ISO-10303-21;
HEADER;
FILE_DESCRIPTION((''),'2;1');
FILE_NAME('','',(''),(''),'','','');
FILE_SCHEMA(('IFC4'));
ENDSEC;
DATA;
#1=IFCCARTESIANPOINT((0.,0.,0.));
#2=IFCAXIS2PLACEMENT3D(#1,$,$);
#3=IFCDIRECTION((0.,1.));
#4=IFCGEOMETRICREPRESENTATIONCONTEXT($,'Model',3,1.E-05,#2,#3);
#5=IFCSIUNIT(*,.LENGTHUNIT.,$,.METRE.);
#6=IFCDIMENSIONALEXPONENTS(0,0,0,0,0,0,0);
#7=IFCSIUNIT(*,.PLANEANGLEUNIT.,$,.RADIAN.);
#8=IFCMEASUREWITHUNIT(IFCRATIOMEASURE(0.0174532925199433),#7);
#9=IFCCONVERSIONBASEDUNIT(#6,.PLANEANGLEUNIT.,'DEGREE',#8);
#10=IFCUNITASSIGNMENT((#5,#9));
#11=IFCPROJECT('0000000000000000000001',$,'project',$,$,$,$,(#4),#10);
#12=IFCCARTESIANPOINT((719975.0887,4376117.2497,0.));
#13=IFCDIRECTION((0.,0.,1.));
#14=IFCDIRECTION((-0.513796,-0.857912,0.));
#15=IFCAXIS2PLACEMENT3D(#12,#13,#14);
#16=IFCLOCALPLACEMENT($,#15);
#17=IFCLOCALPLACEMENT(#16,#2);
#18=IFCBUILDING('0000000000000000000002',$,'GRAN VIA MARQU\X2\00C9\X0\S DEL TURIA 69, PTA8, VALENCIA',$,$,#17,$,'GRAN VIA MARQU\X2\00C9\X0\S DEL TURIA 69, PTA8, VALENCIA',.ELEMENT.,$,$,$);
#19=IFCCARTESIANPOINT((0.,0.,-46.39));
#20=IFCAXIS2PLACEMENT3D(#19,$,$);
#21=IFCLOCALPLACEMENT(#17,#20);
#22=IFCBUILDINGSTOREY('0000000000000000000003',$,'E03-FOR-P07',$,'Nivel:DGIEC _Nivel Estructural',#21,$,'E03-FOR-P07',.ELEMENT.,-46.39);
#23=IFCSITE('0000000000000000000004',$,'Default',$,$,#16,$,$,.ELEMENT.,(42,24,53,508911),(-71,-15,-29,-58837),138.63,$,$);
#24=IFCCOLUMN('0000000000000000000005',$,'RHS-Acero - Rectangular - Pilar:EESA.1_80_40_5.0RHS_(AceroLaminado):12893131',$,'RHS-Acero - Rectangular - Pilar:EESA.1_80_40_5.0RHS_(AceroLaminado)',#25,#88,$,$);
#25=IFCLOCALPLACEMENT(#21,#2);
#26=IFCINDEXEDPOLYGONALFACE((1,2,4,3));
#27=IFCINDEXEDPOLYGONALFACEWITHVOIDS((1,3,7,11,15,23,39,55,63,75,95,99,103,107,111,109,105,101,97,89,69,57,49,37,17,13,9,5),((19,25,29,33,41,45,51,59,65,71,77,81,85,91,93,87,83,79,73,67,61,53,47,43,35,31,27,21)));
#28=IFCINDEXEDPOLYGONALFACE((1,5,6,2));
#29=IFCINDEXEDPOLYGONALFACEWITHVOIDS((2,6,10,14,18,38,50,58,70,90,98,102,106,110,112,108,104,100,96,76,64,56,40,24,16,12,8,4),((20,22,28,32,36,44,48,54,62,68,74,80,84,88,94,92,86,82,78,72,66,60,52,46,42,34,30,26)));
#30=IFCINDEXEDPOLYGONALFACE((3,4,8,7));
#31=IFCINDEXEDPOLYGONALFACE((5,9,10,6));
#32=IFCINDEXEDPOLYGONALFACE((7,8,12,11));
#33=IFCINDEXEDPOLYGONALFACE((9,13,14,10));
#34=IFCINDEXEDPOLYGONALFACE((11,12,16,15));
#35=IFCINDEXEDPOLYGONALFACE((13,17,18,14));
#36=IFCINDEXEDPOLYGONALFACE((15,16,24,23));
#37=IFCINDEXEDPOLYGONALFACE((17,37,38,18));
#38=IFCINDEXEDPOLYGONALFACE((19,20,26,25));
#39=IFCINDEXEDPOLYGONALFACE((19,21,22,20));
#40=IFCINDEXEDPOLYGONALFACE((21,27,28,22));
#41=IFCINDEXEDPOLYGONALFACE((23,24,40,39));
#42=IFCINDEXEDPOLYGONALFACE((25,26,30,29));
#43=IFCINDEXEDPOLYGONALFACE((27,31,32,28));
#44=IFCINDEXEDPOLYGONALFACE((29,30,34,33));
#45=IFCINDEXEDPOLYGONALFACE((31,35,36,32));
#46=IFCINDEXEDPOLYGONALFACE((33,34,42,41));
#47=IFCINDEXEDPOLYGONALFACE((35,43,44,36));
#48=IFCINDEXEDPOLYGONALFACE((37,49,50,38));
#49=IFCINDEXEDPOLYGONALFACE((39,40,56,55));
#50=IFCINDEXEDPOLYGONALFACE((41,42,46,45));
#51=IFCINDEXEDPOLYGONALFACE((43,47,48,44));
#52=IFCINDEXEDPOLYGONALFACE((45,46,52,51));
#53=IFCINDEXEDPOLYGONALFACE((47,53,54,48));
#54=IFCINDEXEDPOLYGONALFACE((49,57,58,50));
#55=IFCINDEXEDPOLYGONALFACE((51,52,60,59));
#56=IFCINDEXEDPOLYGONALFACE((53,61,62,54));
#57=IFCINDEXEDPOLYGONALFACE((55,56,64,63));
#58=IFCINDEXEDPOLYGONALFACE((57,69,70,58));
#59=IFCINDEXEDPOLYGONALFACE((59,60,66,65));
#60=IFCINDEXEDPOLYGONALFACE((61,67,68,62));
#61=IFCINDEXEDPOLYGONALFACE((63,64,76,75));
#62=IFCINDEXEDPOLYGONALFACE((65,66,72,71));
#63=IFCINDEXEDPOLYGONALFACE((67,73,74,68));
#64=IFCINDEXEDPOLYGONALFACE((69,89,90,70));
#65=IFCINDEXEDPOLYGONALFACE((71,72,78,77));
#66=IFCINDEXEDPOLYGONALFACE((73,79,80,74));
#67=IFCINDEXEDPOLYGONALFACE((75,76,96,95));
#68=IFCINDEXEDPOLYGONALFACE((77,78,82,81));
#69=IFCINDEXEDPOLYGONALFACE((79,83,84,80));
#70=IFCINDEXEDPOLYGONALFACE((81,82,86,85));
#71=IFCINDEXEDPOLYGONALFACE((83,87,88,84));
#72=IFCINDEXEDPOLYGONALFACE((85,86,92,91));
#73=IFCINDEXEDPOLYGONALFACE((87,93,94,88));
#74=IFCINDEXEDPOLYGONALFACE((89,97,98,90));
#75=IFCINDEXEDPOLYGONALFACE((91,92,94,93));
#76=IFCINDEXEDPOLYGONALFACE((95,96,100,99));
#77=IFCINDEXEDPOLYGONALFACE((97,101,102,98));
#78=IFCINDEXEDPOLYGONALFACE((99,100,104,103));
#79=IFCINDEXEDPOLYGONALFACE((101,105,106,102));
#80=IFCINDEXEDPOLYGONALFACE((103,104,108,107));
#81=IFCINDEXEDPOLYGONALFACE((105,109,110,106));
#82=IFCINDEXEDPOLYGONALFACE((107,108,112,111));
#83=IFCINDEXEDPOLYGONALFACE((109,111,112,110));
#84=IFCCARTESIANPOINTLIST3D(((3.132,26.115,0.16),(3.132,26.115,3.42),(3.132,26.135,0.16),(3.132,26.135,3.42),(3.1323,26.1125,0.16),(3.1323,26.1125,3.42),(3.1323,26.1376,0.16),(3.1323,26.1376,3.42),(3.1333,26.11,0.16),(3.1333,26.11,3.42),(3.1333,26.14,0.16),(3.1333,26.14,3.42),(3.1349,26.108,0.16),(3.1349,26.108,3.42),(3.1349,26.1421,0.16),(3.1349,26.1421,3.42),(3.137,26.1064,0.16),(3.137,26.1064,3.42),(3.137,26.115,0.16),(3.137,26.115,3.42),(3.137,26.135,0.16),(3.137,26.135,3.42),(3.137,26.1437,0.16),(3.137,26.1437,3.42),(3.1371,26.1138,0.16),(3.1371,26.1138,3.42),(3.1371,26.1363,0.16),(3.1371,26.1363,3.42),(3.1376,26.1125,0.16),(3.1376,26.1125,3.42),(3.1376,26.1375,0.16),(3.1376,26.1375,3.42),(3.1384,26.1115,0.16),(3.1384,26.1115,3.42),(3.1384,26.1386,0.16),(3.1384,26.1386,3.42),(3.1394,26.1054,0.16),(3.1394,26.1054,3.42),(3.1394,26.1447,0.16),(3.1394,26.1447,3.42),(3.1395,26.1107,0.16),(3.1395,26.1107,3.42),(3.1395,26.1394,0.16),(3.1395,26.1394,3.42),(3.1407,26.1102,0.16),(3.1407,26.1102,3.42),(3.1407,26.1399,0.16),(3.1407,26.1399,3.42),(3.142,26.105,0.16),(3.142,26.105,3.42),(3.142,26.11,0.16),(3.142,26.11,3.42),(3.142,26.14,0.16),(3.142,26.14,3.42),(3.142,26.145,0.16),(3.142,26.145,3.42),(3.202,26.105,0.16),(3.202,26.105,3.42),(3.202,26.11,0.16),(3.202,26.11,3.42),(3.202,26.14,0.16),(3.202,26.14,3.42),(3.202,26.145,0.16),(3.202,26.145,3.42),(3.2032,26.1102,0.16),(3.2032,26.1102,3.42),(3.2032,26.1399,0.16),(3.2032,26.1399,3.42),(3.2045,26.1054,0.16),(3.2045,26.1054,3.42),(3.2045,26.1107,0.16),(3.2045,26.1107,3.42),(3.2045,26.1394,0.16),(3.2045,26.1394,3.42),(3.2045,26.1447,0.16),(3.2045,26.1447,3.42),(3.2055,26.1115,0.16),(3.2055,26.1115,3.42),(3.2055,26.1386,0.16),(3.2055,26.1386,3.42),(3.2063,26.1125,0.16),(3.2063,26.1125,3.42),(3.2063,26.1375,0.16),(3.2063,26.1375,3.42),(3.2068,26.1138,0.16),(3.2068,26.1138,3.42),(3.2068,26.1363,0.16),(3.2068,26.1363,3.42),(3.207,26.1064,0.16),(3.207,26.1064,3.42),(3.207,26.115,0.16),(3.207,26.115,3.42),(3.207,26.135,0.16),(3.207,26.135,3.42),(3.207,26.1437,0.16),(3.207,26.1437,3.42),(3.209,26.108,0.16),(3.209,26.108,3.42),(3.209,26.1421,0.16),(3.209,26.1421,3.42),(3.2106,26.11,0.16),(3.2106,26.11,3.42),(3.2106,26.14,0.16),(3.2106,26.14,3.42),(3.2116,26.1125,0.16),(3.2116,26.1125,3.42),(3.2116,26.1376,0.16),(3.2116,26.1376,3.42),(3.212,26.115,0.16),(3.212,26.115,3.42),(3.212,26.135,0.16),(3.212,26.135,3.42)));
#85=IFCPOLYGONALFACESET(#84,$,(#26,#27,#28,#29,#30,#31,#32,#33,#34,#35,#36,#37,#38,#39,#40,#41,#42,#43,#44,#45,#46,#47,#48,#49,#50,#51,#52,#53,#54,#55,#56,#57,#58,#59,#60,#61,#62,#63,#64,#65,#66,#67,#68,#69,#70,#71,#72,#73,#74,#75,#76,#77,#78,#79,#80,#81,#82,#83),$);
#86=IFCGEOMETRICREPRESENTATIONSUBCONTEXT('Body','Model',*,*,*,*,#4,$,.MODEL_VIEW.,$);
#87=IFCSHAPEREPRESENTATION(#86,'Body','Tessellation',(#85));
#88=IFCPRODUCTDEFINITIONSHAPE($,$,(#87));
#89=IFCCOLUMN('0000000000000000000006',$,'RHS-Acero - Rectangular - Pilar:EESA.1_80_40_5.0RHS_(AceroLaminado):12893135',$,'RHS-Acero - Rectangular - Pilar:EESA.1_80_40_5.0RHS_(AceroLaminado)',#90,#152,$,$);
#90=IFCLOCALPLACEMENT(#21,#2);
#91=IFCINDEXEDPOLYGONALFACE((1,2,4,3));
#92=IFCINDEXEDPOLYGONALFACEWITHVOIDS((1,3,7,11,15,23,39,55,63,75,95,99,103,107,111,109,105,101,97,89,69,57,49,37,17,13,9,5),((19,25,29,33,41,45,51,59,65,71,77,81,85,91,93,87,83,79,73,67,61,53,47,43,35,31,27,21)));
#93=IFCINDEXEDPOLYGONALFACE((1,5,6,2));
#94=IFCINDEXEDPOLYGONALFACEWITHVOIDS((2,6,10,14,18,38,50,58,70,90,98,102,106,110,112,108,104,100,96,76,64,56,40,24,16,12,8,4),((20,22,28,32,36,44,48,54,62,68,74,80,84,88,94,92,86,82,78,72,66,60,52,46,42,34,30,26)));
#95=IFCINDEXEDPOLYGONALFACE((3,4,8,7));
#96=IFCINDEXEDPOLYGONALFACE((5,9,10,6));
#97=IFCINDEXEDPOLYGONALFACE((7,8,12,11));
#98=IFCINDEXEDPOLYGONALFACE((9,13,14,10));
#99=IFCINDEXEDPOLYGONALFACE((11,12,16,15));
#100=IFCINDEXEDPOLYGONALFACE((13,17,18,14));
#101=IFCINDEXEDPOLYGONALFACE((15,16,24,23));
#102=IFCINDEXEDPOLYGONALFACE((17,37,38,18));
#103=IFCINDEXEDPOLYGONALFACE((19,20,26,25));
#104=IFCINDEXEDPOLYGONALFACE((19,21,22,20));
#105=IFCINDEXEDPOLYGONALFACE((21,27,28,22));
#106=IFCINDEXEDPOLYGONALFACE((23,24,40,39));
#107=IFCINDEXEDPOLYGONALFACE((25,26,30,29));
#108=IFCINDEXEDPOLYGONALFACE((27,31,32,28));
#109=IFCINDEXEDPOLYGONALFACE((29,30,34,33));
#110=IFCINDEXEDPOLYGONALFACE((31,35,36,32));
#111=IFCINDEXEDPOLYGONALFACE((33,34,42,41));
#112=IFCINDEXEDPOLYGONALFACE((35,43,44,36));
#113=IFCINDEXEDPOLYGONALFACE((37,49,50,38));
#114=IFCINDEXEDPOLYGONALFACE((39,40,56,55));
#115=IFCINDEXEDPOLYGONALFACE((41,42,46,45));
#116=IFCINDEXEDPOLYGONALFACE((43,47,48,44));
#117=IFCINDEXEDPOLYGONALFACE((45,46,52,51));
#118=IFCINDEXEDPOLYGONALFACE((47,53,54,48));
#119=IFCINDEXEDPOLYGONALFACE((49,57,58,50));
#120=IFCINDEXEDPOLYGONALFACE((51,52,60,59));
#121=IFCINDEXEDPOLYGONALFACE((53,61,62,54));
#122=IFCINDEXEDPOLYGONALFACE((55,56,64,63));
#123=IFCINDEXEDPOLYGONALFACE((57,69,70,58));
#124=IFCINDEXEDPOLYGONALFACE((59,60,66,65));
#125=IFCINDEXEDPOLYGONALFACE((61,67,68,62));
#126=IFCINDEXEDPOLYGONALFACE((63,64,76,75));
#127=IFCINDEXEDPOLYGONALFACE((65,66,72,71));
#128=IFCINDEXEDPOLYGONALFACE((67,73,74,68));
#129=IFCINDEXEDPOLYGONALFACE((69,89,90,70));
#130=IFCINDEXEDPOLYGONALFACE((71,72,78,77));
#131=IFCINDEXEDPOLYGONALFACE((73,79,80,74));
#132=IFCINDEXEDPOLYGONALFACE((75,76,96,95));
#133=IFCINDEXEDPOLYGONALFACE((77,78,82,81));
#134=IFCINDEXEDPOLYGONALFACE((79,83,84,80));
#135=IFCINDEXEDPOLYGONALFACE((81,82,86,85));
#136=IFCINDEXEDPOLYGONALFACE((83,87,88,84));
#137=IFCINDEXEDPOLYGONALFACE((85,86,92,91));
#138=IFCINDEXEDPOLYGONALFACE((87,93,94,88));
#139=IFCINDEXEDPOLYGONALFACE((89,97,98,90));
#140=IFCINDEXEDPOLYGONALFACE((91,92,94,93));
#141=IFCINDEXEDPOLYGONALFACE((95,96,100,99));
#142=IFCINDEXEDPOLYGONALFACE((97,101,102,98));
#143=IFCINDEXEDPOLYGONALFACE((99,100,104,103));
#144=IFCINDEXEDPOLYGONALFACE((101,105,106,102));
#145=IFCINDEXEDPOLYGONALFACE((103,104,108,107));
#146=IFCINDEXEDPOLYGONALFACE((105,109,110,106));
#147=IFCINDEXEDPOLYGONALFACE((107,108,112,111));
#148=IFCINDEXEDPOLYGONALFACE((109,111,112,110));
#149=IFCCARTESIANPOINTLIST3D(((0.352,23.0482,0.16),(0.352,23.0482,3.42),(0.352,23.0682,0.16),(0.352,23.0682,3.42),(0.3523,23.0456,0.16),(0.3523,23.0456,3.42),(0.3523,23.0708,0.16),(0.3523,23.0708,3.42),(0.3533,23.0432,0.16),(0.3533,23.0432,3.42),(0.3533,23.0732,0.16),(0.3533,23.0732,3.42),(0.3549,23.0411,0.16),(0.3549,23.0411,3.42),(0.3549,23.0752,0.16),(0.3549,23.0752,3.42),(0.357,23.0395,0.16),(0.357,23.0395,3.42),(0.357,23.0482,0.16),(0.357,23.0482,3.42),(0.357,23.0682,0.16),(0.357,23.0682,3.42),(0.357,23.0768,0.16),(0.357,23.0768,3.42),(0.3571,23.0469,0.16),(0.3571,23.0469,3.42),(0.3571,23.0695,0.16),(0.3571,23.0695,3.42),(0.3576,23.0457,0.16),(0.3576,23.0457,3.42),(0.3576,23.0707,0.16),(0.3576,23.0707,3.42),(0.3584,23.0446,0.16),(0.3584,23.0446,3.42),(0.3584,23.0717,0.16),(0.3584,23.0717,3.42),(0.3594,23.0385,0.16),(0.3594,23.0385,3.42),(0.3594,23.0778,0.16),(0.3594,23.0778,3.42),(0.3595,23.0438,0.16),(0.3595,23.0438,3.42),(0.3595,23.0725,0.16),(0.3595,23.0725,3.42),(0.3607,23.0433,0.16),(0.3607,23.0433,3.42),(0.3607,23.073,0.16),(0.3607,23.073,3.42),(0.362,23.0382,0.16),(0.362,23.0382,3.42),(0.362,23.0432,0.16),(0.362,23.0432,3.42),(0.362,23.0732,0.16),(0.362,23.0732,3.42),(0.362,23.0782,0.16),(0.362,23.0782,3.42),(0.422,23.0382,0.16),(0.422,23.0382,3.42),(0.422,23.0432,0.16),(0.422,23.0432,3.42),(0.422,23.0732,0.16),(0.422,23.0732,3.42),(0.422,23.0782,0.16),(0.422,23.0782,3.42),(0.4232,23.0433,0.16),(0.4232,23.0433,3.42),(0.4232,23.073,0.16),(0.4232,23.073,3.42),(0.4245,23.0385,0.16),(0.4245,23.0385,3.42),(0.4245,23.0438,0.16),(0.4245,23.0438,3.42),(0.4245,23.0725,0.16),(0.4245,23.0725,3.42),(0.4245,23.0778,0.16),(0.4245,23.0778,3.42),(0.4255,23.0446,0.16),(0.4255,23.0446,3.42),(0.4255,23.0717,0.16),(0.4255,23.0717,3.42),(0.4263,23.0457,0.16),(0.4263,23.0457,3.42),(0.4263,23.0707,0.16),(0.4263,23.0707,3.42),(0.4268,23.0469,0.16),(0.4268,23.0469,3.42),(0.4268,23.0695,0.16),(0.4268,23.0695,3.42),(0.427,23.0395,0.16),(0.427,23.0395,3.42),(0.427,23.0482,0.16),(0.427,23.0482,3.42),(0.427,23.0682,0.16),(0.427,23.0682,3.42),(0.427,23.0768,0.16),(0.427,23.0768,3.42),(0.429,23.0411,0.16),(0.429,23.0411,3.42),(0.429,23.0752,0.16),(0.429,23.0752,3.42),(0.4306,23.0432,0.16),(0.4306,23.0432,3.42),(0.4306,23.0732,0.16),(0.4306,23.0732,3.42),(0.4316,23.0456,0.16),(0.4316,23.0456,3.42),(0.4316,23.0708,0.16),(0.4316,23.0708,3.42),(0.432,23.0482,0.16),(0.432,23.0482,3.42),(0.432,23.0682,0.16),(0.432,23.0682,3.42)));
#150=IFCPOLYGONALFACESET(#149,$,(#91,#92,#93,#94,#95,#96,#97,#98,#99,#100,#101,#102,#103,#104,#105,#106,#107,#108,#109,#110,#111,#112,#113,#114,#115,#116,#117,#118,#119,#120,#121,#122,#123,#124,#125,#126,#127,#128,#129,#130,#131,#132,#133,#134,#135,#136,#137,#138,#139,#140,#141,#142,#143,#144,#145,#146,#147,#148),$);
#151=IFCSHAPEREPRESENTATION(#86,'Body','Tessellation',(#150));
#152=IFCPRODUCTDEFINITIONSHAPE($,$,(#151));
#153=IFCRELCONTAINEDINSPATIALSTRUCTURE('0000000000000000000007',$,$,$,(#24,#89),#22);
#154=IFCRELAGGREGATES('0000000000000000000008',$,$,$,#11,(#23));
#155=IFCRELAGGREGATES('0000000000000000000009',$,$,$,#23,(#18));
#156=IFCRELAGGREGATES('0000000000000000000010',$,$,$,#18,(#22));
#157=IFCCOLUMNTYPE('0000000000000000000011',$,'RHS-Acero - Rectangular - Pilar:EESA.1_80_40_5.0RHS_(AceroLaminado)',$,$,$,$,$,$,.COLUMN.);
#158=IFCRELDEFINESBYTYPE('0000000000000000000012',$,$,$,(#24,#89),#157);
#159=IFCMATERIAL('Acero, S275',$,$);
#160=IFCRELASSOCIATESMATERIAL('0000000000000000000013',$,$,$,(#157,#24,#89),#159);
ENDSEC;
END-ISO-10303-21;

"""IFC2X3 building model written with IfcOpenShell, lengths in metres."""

from ifc_helpers import new_model, entity, si_unit, converted_unit, direction, frame, frame_2d, origin, place, context, subcontext, project, spatial, polyline, circle_curve, parameter, trimmed, segment, composite_curve, outline, extrude, source, transform, mapped, material, type_object, type_shapes, element, save


model = new_model("IFC2X3")

# Units and contexts
model_context = context("Model", 3, precision=1e-05, world=origin(), true_north=direction((0.0, 1.0)))
body_context = subcontext(model_context, "Body", "Model", "MODEL_VIEW")
ifc_project = project(units=[si_unit("LENGTHUNIT", "METRE"), converted_unit("PLANEANGLEUNIT", "DEGREE", entity("IfcRatioMeasure", 0.0174532925199433), si_unit("PLANEANGLEUNIT", "RADIAN"), dimensions=[0, 0, 0, 0, 0, 0, 0])], contexts=[model_context])

# Site, building, storey
site_placement = place(None, frame((719975.0887, 4376117.2497, 0.0), z_axis=(0.0, 0.0, 1.0), x_axis=(-0.513796, -0.857912, 0.0)))
site = spatial("IfcSite", under=ifc_project, at=site_placement, Name="Default", CompositionType="ELEMENT", RefLatitude=(42, 24, 53, 508911), RefLongitude=(-71, -15, -29, -58837), RefElevation=138.63)
building_placement = place(site_placement, origin())
building = spatial("IfcBuilding", under=site, at=building_placement, Name="GRAN VIA MARQUÉS DEL TURIA 69, PTA8, VALENCIA", LongName="GRAN VIA MARQUÉS DEL TURIA 69, PTA8, VALENCIA", CompositionType="ELEMENT")
storey_placement = place(building_placement, frame((0.0, 0.0, -46.39)))
storey = spatial("IfcBuildingStorey", under=building, at=storey_placement, Name="E03-FOR-P07", ObjectType="Nivel:DGIEC _Nivel Estructural", LongName="E03-FOR-P07", CompositionType="ELEMENT", Elevation=-46.39)

# Columns
ifc_material = material(Name="Acero, S275")
column_type_1 = type_object("IfcColumnType", Name="RHS-Acero - Rectangular - Pilar:EESA.1_80_40_5.0RHS_(AceroLaminado)", PredefinedType="COLUMN", material=ifc_material)
shared_shape_1 = source(origin(), body_context, "Body", "SweptSolid", [
    extrude(outline(composite_curve([segment(polyline([(-0.01, -0.04), (0.01, -0.04)]), True, "CONTINUOUS"), segment(trimmed(circle_curve(frame_2d((0.01, -0.03), x_axis=(-1.0, 0.0)), 0.01), [parameter(90.0)], [parameter(180.0)], True, "PARAMETER"), True, "CONTINUOUS"), segment(polyline([(0.02, -0.03), (0.02, 0.03)]), True, "CONTINUOUS"), segment(trimmed(circle_curve(frame_2d((0.01, 0.03), x_axis=(-1.0, 0.0)), 0.01), [parameter(180.0)], [parameter(270.0)], True, "PARAMETER"), True, "CONTINUOUS"), segment(polyline([(0.01, 0.04), (-0.01, 0.04)]), True, "CONTINUOUS"), segment(trimmed(circle_curve(frame_2d((-0.01, 0.03), x_axis=(-1.0, 0.0)), 0.01), [parameter(270.0)], [parameter(360.0)], True, "PARAMETER"), True, "CONTINUOUS"), segment(polyline([(-0.02, 0.03), (-0.02, -0.03)]), True, "CONTINUOUS"), segment(trimmed(circle_curve(frame_2d((-0.01, -0.03), x_axis=(-1.0, 0.0)), 0.01), [parameter(360.0)], [parameter(90.0)], True, "PARAMETER"), True, "CONTINUOUS")], self_intersect=False), holes=[composite_curve([segment(trimmed(circle_curve(frame_2d((-0.01, -0.03), x_axis=(-1.0, 0.0)), 0.005), [parameter(0.0)], [parameter(90.0)], True, "PARAMETER"), False, "CONTINUOUS"), segment(polyline([(-0.015, -0.03), (-0.015, 0.03)]), True, "CONTINUOUS"), segment(trimmed(circle_curve(frame_2d((-0.01, 0.03), x_axis=(-1.0, 0.0)), 0.005), [parameter(270.0)], [parameter(0.0)], True, "PARAMETER"), False, "CONTINUOUS"), segment(polyline([(-0.01, 0.035), (0.01, 0.035)]), True, "CONTINUOUS"), segment(trimmed(circle_curve(frame_2d((0.01, 0.03), x_axis=(-1.0, 0.0)), 0.005), [parameter(180.0)], [parameter(270.0)], True, "PARAMETER"), False, "CONTINUOUS"), segment(polyline([(0.015, 0.03), (0.015, -0.03)]), True, "CONTINUOUS"), segment(trimmed(circle_curve(frame_2d((0.01, -0.03), x_axis=(-1.0, 0.0)), 0.005), [parameter(90.0)], [parameter(180.0)], True, "PARAMETER"), False, "CONTINUOUS"), segment(polyline([(0.01, -0.035), (-0.01, -0.035)]), True, "CONTINUOUS")], self_intersect=False)]), frame((0.0, 0.0, -46.23), z_axis=(0.0, 0.0, 1.0), x_axis=(-1.0, 0.0, 0.0)), (0.0, 0.0, 1.0), 3.26),
])
type_shapes(column_type_1, [shared_shape_1])
for number, where, z_axis, x_axis, name in (
    (1, (3.172, 26.125, 46.39), (0.0, 0.0, 1.0), (0.0, 1.0, 0.0), "RHS-Acero - Rectangular - Pilar:EESA.1_80_40_5.0RHS_(AceroLaminado):12893131"),
    (2, (0.392, 23.0582, 46.39), (0.0, 0.0, 1.0), (0.0, 1.0, 0.0), "RHS-Acero - Rectangular - Pilar:EESA.1_80_40_5.0RHS_(AceroLaminado):12893135"),
):
    element("IfcColumn", number, at=place(storey_placement, frame(where, z_axis=z_axis, x_axis=x_axis)), inside=storey, type_object=column_type_1, material=ifc_material, Name=name, ObjectType="RHS-Acero - Rectangular - Pilar:EESA.1_80_40_5.0RHS_(AceroLaminado)", context=body_context, shape_type="MappedRepresentation", body=[
        mapped(shared_shape_1, transform((0.0, 0.0, 0.0), scale=1.0)),
    ])

save(model, "model.ifc")
